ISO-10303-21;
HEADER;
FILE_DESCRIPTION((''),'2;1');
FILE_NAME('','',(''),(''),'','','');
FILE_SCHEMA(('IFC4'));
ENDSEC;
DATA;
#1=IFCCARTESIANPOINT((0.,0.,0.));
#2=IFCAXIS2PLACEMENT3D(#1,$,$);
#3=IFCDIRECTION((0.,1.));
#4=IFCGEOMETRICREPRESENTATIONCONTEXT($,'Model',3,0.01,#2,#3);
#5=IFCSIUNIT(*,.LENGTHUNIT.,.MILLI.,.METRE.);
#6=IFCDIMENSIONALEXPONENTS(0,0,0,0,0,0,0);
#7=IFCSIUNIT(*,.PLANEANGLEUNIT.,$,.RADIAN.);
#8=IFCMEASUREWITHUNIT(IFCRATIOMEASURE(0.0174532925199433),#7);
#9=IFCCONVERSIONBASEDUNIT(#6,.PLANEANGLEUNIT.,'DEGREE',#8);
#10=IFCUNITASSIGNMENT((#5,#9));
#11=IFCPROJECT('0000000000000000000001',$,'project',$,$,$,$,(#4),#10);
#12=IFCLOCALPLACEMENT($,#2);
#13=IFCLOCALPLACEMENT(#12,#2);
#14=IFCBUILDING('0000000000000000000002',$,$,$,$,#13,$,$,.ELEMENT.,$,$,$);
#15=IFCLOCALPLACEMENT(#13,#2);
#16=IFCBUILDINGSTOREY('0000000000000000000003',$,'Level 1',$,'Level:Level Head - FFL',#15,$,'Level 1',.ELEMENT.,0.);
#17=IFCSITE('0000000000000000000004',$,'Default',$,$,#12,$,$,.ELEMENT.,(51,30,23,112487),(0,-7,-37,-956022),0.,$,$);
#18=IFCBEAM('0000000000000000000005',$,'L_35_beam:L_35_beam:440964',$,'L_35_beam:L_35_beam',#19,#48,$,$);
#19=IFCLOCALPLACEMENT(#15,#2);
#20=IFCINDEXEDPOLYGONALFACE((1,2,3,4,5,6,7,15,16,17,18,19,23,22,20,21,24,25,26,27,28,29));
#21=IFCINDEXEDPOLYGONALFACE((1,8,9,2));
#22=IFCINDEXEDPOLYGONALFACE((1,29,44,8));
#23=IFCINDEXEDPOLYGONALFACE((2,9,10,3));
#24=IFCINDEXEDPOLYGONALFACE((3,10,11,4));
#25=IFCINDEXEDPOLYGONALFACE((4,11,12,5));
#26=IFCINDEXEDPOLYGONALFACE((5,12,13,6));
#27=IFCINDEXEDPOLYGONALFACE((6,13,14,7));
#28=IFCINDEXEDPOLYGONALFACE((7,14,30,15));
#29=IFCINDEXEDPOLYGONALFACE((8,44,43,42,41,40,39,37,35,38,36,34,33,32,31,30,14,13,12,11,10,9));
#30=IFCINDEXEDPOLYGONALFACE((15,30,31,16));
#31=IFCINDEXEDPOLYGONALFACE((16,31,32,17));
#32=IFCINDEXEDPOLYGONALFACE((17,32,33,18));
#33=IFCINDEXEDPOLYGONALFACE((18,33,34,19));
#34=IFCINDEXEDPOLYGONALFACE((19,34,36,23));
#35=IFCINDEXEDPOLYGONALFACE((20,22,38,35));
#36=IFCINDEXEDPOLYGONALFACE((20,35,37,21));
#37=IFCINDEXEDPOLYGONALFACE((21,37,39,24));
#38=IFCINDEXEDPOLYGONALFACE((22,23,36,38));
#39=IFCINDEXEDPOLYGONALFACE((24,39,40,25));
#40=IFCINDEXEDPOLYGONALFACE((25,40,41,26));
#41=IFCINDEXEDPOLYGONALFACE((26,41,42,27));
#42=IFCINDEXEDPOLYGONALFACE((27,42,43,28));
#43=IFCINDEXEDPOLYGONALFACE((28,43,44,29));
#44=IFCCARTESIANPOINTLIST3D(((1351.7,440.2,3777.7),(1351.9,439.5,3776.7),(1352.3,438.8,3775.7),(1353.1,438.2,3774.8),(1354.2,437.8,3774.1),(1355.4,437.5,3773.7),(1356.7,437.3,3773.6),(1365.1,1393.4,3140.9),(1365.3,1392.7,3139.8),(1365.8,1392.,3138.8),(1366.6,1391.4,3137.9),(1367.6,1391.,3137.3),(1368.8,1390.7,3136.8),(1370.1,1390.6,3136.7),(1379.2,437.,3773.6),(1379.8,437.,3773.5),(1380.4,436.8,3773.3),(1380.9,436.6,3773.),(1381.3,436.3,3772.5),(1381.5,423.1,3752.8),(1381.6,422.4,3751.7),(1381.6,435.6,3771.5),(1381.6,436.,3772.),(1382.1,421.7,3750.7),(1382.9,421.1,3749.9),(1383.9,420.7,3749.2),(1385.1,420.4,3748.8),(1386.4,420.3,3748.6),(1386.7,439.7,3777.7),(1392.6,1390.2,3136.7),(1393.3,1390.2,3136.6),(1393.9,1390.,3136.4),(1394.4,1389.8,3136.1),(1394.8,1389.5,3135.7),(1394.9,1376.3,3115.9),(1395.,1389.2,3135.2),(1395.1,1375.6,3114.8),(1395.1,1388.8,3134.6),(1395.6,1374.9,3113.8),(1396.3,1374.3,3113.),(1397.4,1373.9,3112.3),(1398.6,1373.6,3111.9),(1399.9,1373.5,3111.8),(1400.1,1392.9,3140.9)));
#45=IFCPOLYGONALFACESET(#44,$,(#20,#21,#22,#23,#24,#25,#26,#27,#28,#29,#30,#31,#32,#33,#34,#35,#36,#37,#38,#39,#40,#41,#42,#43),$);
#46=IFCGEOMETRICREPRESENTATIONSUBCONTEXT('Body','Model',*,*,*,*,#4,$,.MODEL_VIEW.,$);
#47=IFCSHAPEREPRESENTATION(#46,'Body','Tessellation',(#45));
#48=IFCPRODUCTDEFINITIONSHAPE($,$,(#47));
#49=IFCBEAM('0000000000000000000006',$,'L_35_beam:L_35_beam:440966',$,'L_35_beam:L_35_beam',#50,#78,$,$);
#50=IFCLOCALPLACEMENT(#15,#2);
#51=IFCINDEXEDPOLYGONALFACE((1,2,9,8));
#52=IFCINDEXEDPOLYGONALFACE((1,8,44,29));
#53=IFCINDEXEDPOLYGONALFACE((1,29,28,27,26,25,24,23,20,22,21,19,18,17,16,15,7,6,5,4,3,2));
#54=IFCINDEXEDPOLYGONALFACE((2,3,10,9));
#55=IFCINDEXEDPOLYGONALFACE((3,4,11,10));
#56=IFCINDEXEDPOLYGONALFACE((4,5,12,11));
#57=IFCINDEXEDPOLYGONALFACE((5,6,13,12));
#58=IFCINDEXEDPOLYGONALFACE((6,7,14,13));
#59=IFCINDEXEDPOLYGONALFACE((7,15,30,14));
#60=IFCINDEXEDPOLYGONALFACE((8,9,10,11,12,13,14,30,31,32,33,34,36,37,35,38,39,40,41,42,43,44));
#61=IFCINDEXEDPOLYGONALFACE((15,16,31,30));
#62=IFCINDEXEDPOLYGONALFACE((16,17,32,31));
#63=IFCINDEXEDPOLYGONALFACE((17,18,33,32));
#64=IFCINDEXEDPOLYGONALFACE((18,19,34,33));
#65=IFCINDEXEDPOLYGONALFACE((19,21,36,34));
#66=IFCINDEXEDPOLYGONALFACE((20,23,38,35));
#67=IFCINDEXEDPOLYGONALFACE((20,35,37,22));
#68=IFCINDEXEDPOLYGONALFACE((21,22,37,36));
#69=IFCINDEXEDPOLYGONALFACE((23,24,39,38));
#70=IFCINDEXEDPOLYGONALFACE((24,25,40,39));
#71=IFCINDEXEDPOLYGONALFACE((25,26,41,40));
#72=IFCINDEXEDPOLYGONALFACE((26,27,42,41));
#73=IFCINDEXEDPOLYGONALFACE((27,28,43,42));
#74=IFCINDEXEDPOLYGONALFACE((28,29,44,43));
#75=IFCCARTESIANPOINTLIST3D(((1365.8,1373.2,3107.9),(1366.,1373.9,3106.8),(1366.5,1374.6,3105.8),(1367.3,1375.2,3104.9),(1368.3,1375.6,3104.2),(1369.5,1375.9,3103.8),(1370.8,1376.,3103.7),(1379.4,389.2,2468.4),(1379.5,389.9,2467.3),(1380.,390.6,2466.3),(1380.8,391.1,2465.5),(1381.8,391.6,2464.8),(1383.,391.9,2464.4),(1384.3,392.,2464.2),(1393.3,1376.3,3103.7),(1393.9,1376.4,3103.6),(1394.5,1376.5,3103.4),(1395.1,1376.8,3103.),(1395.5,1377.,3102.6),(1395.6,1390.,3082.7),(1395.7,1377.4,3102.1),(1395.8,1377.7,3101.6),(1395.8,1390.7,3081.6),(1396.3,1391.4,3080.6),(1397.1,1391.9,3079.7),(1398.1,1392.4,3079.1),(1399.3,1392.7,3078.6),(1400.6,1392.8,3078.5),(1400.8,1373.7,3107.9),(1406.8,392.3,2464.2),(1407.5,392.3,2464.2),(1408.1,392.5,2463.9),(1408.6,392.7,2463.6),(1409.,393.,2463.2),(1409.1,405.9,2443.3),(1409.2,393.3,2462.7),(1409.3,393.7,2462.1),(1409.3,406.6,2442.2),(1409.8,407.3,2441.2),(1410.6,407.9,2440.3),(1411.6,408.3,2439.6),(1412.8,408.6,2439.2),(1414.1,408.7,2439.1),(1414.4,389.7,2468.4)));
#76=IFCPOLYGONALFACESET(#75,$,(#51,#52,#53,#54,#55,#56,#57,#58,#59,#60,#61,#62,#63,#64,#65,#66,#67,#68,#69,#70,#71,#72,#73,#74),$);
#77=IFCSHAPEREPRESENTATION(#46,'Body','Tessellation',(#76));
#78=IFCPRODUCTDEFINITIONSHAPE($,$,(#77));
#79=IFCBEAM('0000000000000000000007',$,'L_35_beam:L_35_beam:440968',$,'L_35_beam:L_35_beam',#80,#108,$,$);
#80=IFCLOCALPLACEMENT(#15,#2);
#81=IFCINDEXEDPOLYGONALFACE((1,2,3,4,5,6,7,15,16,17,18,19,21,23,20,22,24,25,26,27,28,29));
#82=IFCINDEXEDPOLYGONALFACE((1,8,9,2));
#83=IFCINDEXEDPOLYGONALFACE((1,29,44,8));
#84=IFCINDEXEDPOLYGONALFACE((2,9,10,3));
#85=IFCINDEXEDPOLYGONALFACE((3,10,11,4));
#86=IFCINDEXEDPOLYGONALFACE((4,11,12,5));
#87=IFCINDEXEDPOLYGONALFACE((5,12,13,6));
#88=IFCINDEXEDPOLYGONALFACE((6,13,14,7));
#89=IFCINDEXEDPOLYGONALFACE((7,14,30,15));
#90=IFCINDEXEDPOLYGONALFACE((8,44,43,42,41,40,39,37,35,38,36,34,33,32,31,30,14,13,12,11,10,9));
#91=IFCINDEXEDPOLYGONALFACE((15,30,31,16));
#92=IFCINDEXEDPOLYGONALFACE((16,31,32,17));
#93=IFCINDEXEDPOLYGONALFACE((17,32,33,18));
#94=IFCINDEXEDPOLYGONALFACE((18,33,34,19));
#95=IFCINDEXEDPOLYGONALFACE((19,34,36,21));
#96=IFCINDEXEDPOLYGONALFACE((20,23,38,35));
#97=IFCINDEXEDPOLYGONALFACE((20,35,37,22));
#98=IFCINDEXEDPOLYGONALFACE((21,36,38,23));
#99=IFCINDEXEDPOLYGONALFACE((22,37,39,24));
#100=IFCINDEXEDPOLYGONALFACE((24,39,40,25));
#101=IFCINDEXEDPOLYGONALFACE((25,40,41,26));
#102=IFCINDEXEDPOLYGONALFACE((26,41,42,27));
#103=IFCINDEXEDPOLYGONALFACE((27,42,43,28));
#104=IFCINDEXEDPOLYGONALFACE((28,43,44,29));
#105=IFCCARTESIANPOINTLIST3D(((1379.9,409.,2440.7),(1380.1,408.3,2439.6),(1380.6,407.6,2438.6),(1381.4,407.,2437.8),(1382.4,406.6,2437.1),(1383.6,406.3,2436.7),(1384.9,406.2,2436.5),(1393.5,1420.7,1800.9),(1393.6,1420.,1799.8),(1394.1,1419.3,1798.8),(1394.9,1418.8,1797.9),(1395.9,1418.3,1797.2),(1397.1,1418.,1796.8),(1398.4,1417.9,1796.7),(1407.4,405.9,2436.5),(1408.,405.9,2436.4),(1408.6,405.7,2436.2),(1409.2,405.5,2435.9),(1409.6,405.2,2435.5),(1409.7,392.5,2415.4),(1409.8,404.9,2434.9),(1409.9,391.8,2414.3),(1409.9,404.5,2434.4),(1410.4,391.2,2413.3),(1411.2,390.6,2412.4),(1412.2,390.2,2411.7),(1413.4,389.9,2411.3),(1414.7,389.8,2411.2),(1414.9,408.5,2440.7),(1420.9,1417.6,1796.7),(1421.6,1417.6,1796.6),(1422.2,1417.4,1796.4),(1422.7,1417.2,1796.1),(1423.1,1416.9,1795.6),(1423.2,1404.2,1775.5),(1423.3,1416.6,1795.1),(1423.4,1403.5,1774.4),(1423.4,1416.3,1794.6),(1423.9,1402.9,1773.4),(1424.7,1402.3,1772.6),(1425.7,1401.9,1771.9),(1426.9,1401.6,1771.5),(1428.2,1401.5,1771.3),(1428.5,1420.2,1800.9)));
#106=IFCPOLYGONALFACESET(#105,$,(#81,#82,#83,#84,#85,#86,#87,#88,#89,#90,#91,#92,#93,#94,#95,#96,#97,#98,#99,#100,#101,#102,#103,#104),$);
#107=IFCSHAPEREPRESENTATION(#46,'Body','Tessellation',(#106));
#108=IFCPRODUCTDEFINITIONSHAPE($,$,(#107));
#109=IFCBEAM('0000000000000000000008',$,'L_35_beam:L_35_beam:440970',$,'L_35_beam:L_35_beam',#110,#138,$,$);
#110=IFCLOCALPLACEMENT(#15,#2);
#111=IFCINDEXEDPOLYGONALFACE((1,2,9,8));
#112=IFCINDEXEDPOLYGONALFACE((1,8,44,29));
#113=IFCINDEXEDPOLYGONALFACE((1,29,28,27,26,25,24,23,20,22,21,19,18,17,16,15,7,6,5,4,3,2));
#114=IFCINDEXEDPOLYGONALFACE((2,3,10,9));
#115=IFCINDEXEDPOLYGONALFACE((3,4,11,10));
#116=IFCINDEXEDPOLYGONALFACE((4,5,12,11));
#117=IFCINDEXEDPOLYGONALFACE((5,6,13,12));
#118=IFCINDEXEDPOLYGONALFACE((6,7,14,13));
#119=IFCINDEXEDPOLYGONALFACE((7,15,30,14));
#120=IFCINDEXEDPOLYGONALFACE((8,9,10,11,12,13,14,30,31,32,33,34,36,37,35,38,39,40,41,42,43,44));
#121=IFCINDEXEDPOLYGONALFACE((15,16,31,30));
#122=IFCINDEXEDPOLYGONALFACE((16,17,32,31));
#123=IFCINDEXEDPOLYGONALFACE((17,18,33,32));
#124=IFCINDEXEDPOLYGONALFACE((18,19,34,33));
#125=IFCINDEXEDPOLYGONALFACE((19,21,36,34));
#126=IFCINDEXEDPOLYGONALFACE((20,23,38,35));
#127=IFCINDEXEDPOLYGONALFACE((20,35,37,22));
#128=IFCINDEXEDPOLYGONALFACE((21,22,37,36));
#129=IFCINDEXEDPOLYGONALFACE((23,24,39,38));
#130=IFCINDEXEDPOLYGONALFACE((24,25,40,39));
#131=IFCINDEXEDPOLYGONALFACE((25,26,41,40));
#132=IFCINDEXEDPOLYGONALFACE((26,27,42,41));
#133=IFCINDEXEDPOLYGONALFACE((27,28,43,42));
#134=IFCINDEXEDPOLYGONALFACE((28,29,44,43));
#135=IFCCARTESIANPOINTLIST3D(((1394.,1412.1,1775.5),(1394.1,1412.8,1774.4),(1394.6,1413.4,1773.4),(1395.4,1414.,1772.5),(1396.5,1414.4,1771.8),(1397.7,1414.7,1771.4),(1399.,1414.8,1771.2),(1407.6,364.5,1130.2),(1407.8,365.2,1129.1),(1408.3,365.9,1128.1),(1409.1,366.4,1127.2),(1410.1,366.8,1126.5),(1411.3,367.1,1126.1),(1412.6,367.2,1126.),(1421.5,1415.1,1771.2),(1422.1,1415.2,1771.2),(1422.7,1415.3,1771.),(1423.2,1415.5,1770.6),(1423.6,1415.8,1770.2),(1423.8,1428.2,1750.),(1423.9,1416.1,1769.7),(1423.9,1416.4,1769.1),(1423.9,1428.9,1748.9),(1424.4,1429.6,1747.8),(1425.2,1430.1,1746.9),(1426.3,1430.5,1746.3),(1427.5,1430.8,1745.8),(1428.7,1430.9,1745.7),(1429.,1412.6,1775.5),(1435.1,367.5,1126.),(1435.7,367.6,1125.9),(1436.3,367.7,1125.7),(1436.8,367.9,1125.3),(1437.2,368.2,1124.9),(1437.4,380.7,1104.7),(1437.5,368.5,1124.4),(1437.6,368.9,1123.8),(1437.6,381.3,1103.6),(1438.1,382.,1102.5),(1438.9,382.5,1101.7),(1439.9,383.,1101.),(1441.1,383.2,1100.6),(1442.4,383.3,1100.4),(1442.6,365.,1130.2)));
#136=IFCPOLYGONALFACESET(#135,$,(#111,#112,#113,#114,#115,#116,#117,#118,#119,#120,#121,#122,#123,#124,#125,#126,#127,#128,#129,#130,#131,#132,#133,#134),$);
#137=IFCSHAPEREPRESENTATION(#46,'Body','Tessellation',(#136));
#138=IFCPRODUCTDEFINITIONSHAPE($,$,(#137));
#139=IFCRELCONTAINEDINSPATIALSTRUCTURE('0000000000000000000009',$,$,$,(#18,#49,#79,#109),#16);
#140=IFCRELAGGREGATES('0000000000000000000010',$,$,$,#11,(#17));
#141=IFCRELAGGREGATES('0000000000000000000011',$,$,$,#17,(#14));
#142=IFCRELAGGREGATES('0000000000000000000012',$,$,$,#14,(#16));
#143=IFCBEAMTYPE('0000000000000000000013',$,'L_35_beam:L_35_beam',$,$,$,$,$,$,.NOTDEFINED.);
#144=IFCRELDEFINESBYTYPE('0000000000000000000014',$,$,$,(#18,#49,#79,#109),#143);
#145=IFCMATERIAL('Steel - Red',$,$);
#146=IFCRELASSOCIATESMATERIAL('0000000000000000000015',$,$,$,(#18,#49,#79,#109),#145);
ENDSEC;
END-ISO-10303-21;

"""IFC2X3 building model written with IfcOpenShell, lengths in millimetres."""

from ifc_helpers import new_model, entity, si_unit, converted_unit, direction, frame, frame_2d, origin, place, context, subcontext, project, spatial, polyline, circle_curve, parameter, trimmed, segment, composite_curve, outline, extrude, material, type_object, element, save


model = new_model("IFC2X3")

# Units and contexts
model_context = context("Model", 3, precision=0.01, world=origin(), true_north=direction((0.0, 1.0)))
body_context = subcontext(model_context, "Body", "Model", "MODEL_VIEW")
ifc_project = project(units=[si_unit("LENGTHUNIT", "METRE", prefix="MILLI"), converted_unit("PLANEANGLEUNIT", "DEGREE", entity("IfcRatioMeasure", 0.0174532925199433), si_unit("PLANEANGLEUNIT", "RADIAN"), dimensions=[0, 0, 0, 0, 0, 0, 0])], contexts=[model_context])

# Site, building, storey
site_placement = place(None, origin())
site = spatial("IfcSite", under=ifc_project, at=site_placement, Name="Default", CompositionType="ELEMENT", RefLatitude=(51, 30, 23, 112487), RefLongitude=(0, -7, -37, -956022), RefElevation=0.0)
building_placement = place(site_placement, origin())
building = spatial("IfcBuilding", under=site, at=building_placement, CompositionType="ELEMENT")
storey_placement = place(building_placement, origin())
storey = spatial("IfcBuildingStorey", under=building, at=storey_placement, Name="Level 1", ObjectType="Level:Level Head - FFL", LongName="Level 1", CompositionType="ELEMENT", Elevation=0.0)

# Beams
ifc_material_1 = material(Name="Steel - Red")
beam_type = type_object("IfcBeamType", Name="L_35_beam:L_35_beam", PredefinedType="NOTDEFINED")
beam_1_placement = place(storey_placement, frame((1408.4, 1408.4, 3109.4), z_axis=(0.007842, 0.555459, 0.831507), x_axis=(-0.011738, -0.831424, 0.555515)))
element("IfcBeam", 1, at=beam_1_placement, inside=storey, type_object=beam_type, material=ifc_material_1, Name="L_35_beam:L_35_beam:440964", ObjectType="L_35_beam:L_35_beam", context=body_context, shape_type="SweptSolid", body=[
    extrude(outline(composite_curve([segment(polyline([(-23.2, -11.8), (11.8, -11.8)]), True, "CONTINUOUS"), segment(polyline([(11.8, -11.8), (11.8, 23.2)]), True, "CONTINUOUS"), segment(trimmed(circle_curve(frame_2d((11.8, 18.2), x_axis=(0.0, 1.0)), 5.0), [parameter(0.0)], [parameter(90.0)], True, "PARAMETER"), True, "CONTINUOUS"), segment(polyline([(6.8, 18.2), (6.8, -4.3)]), True, "CONTINUOUS"), segment(trimmed(circle_curve(frame_2d((4.3, -4.3), x_axis=(1.0, 0.0)), 2.5), [parameter(270.0)], [parameter(0.0)], True, "PARAMETER"), False, "CONTINUOUS"), segment(polyline([(4.3, -6.8), (-18.2, -6.8)]), True, "CONTINUOUS"), segment(trimmed(circle_curve(frame_2d((-18.2, -11.8), x_axis=(0.0, 1.0)), 5.0), [parameter(0.0)], [parameter(90.0)], True, "PARAMETER"), True, "CONTINUOUS")], self_intersect=False)), frame((30.4, -19.8, 5.7), z_axis=(1.0, 0.0, 0.0), x_axis=(0.0, 0.0, 1.0)), (0.0, 0.0, 1.0), 1146.5),
])
beam_2_placement = place(storey_placement, frame((1408.4, 1408.4, 3109.4), z_axis=(0.00748, -0.544781, 0.838545), x_axis=(0.011512, -0.838466, -0.544833)))
element("IfcBeam", 2, at=beam_2_placement, inside=storey, type_object=beam_type, material=ifc_material_1, Name="L_35_beam:L_35_beam:440966", ObjectType="L_35_beam:L_35_beam", context=body_context, shape_type="SweptSolid", body=[
    extrude(outline(composite_curve([segment(polyline([(-23.2, -11.8), (11.8, -11.8)]), True, "CONTINUOUS"), segment(polyline([(11.8, -11.8), (11.8, 23.2)]), True, "CONTINUOUS"), segment(trimmed(circle_curve(frame_2d((11.8, 18.2), x_axis=(0.0, 1.0)), 5.0), [parameter(0.0)], [parameter(90.0)], True, "PARAMETER"), True, "CONTINUOUS"), segment(polyline([(6.8, 18.2), (6.8, -4.3)]), True, "CONTINUOUS"), segment(trimmed(circle_curve(frame_2d((4.3, -4.3), x_axis=(1.0, 0.0)), 2.5), [parameter(270.0)], [parameter(0.0)], True, "PARAMETER"), False, "CONTINUOUS"), segment(polyline([(4.3, -6.8), (-18.2, -6.8)]), True, "CONTINUOUS"), segment(trimmed(circle_curve(frame_2d((-18.2, -11.8), x_axis=(0.0, 1.0)), 5.0), [parameter(0.0)], [parameter(90.0)], True, "PARAMETER"), True, "CONTINUOUS")], self_intersect=False)), frame((29.8, -19.8, 5.7), z_axis=(1.0, 0.0, 0.0), x_axis=(0.0, 0.0, 1.0)), (0.0, 0.0, 1.0), 1173.6),
])
beam_3_placement = place(storey_placement, frame((1436.7, 1436.7, 1769.7), z_axis=(0.007141, 0.534423, 0.845187), x_axis=(-0.011293, -0.845111, 0.534471)))
element("IfcBeam", 3, at=beam_3_placement, inside=storey, type_object=beam_type, material=ifc_material_1, Name="L_35_beam:L_35_beam:440968", ObjectType="L_35_beam:L_35_beam", context=body_context, shape_type="SweptSolid", body=[
    extrude(outline(composite_curve([segment(polyline([(-23.2, -11.8), (11.8, -11.8)]), True, "CONTINUOUS"), segment(polyline([(11.8, -11.8), (11.8, 23.2)]), True, "CONTINUOUS"), segment(trimmed(circle_curve(frame_2d((11.8, 18.2), x_axis=(0.0, 1.0)), 5.0), [parameter(0.0)], [parameter(90.0)], True, "PARAMETER"), True, "CONTINUOUS"), segment(polyline([(6.8, 18.2), (6.8, -4.3)]), True, "CONTINUOUS"), segment(trimmed(circle_curve(frame_2d((4.3, -4.3), x_axis=(1.0, 0.0)), 2.5), [parameter(270.0)], [parameter(0.0)], True, "PARAMETER"), False, "CONTINUOUS"), segment(polyline([(4.3, -6.8), (-18.2, -6.8)]), True, "CONTINUOUS"), segment(trimmed(circle_curve(frame_2d((-18.2, -11.8), x_axis=(0.0, 1.0)), 5.0), [parameter(0.0)], [parameter(90.0)], True, "PARAMETER"), True, "CONTINUOUS")], self_intersect=False)), frame((30.7, -19.8, 5.7), z_axis=(1.0, 0.0, 0.0), x_axis=(0.0, 0.0, 1.0)), (0.0, 0.0, 1.0), 1197.1),
])
beam_4_placement = place(storey_placement, frame((1436.7, 1436.7, 1769.7), z_axis=(0.006825, -0.524377, 0.851459), x_axis=(0.011081, -0.851387, -0.524421)))
element("IfcBeam", 4, at=beam_4_placement, inside=storey, type_object=beam_type, material=ifc_material_1, Name="L_35_beam:L_35_beam:440970", ObjectType="L_35_beam:L_35_beam", context=body_context, shape_type="SweptSolid", body=[
    extrude(outline(composite_curve([segment(polyline([(-23.2, -11.8), (11.8, -11.8)]), True, "CONTINUOUS"), segment(polyline([(11.8, -11.8), (11.8, 23.2)]), True, "CONTINUOUS"), segment(trimmed(circle_curve(frame_2d((11.8, 18.2), x_axis=(0.0, 1.0)), 5.0), [parameter(0.0)], [parameter(90.0)], True, "PARAMETER"), True, "CONTINUOUS"), segment(polyline([(6.8, 18.2), (6.8, -4.3)]), True, "CONTINUOUS"), segment(trimmed(circle_curve(frame_2d((4.3, -4.3), x_axis=(1.0, 0.0)), 2.5), [parameter(270.0)], [parameter(0.0)], True, "PARAMETER"), False, "CONTINUOUS"), segment(polyline([(4.3, -6.8), (-18.2, -6.8)]), True, "CONTINUOUS"), segment(trimmed(circle_curve(frame_2d((-18.2, -11.8), x_axis=(0.0, 1.0)), 5.0), [parameter(0.0)], [parameter(90.0)], True, "PARAMETER"), True, "CONTINUOUS")], self_intersect=False)), frame((17.4, -19.8, 5.7), z_axis=(1.0, 0.0, 0.0), x_axis=(0.0, 0.0, 1.0)), (0.0, 0.0, 1.0), 1230.4),
])

save(model, "model.ifc")
